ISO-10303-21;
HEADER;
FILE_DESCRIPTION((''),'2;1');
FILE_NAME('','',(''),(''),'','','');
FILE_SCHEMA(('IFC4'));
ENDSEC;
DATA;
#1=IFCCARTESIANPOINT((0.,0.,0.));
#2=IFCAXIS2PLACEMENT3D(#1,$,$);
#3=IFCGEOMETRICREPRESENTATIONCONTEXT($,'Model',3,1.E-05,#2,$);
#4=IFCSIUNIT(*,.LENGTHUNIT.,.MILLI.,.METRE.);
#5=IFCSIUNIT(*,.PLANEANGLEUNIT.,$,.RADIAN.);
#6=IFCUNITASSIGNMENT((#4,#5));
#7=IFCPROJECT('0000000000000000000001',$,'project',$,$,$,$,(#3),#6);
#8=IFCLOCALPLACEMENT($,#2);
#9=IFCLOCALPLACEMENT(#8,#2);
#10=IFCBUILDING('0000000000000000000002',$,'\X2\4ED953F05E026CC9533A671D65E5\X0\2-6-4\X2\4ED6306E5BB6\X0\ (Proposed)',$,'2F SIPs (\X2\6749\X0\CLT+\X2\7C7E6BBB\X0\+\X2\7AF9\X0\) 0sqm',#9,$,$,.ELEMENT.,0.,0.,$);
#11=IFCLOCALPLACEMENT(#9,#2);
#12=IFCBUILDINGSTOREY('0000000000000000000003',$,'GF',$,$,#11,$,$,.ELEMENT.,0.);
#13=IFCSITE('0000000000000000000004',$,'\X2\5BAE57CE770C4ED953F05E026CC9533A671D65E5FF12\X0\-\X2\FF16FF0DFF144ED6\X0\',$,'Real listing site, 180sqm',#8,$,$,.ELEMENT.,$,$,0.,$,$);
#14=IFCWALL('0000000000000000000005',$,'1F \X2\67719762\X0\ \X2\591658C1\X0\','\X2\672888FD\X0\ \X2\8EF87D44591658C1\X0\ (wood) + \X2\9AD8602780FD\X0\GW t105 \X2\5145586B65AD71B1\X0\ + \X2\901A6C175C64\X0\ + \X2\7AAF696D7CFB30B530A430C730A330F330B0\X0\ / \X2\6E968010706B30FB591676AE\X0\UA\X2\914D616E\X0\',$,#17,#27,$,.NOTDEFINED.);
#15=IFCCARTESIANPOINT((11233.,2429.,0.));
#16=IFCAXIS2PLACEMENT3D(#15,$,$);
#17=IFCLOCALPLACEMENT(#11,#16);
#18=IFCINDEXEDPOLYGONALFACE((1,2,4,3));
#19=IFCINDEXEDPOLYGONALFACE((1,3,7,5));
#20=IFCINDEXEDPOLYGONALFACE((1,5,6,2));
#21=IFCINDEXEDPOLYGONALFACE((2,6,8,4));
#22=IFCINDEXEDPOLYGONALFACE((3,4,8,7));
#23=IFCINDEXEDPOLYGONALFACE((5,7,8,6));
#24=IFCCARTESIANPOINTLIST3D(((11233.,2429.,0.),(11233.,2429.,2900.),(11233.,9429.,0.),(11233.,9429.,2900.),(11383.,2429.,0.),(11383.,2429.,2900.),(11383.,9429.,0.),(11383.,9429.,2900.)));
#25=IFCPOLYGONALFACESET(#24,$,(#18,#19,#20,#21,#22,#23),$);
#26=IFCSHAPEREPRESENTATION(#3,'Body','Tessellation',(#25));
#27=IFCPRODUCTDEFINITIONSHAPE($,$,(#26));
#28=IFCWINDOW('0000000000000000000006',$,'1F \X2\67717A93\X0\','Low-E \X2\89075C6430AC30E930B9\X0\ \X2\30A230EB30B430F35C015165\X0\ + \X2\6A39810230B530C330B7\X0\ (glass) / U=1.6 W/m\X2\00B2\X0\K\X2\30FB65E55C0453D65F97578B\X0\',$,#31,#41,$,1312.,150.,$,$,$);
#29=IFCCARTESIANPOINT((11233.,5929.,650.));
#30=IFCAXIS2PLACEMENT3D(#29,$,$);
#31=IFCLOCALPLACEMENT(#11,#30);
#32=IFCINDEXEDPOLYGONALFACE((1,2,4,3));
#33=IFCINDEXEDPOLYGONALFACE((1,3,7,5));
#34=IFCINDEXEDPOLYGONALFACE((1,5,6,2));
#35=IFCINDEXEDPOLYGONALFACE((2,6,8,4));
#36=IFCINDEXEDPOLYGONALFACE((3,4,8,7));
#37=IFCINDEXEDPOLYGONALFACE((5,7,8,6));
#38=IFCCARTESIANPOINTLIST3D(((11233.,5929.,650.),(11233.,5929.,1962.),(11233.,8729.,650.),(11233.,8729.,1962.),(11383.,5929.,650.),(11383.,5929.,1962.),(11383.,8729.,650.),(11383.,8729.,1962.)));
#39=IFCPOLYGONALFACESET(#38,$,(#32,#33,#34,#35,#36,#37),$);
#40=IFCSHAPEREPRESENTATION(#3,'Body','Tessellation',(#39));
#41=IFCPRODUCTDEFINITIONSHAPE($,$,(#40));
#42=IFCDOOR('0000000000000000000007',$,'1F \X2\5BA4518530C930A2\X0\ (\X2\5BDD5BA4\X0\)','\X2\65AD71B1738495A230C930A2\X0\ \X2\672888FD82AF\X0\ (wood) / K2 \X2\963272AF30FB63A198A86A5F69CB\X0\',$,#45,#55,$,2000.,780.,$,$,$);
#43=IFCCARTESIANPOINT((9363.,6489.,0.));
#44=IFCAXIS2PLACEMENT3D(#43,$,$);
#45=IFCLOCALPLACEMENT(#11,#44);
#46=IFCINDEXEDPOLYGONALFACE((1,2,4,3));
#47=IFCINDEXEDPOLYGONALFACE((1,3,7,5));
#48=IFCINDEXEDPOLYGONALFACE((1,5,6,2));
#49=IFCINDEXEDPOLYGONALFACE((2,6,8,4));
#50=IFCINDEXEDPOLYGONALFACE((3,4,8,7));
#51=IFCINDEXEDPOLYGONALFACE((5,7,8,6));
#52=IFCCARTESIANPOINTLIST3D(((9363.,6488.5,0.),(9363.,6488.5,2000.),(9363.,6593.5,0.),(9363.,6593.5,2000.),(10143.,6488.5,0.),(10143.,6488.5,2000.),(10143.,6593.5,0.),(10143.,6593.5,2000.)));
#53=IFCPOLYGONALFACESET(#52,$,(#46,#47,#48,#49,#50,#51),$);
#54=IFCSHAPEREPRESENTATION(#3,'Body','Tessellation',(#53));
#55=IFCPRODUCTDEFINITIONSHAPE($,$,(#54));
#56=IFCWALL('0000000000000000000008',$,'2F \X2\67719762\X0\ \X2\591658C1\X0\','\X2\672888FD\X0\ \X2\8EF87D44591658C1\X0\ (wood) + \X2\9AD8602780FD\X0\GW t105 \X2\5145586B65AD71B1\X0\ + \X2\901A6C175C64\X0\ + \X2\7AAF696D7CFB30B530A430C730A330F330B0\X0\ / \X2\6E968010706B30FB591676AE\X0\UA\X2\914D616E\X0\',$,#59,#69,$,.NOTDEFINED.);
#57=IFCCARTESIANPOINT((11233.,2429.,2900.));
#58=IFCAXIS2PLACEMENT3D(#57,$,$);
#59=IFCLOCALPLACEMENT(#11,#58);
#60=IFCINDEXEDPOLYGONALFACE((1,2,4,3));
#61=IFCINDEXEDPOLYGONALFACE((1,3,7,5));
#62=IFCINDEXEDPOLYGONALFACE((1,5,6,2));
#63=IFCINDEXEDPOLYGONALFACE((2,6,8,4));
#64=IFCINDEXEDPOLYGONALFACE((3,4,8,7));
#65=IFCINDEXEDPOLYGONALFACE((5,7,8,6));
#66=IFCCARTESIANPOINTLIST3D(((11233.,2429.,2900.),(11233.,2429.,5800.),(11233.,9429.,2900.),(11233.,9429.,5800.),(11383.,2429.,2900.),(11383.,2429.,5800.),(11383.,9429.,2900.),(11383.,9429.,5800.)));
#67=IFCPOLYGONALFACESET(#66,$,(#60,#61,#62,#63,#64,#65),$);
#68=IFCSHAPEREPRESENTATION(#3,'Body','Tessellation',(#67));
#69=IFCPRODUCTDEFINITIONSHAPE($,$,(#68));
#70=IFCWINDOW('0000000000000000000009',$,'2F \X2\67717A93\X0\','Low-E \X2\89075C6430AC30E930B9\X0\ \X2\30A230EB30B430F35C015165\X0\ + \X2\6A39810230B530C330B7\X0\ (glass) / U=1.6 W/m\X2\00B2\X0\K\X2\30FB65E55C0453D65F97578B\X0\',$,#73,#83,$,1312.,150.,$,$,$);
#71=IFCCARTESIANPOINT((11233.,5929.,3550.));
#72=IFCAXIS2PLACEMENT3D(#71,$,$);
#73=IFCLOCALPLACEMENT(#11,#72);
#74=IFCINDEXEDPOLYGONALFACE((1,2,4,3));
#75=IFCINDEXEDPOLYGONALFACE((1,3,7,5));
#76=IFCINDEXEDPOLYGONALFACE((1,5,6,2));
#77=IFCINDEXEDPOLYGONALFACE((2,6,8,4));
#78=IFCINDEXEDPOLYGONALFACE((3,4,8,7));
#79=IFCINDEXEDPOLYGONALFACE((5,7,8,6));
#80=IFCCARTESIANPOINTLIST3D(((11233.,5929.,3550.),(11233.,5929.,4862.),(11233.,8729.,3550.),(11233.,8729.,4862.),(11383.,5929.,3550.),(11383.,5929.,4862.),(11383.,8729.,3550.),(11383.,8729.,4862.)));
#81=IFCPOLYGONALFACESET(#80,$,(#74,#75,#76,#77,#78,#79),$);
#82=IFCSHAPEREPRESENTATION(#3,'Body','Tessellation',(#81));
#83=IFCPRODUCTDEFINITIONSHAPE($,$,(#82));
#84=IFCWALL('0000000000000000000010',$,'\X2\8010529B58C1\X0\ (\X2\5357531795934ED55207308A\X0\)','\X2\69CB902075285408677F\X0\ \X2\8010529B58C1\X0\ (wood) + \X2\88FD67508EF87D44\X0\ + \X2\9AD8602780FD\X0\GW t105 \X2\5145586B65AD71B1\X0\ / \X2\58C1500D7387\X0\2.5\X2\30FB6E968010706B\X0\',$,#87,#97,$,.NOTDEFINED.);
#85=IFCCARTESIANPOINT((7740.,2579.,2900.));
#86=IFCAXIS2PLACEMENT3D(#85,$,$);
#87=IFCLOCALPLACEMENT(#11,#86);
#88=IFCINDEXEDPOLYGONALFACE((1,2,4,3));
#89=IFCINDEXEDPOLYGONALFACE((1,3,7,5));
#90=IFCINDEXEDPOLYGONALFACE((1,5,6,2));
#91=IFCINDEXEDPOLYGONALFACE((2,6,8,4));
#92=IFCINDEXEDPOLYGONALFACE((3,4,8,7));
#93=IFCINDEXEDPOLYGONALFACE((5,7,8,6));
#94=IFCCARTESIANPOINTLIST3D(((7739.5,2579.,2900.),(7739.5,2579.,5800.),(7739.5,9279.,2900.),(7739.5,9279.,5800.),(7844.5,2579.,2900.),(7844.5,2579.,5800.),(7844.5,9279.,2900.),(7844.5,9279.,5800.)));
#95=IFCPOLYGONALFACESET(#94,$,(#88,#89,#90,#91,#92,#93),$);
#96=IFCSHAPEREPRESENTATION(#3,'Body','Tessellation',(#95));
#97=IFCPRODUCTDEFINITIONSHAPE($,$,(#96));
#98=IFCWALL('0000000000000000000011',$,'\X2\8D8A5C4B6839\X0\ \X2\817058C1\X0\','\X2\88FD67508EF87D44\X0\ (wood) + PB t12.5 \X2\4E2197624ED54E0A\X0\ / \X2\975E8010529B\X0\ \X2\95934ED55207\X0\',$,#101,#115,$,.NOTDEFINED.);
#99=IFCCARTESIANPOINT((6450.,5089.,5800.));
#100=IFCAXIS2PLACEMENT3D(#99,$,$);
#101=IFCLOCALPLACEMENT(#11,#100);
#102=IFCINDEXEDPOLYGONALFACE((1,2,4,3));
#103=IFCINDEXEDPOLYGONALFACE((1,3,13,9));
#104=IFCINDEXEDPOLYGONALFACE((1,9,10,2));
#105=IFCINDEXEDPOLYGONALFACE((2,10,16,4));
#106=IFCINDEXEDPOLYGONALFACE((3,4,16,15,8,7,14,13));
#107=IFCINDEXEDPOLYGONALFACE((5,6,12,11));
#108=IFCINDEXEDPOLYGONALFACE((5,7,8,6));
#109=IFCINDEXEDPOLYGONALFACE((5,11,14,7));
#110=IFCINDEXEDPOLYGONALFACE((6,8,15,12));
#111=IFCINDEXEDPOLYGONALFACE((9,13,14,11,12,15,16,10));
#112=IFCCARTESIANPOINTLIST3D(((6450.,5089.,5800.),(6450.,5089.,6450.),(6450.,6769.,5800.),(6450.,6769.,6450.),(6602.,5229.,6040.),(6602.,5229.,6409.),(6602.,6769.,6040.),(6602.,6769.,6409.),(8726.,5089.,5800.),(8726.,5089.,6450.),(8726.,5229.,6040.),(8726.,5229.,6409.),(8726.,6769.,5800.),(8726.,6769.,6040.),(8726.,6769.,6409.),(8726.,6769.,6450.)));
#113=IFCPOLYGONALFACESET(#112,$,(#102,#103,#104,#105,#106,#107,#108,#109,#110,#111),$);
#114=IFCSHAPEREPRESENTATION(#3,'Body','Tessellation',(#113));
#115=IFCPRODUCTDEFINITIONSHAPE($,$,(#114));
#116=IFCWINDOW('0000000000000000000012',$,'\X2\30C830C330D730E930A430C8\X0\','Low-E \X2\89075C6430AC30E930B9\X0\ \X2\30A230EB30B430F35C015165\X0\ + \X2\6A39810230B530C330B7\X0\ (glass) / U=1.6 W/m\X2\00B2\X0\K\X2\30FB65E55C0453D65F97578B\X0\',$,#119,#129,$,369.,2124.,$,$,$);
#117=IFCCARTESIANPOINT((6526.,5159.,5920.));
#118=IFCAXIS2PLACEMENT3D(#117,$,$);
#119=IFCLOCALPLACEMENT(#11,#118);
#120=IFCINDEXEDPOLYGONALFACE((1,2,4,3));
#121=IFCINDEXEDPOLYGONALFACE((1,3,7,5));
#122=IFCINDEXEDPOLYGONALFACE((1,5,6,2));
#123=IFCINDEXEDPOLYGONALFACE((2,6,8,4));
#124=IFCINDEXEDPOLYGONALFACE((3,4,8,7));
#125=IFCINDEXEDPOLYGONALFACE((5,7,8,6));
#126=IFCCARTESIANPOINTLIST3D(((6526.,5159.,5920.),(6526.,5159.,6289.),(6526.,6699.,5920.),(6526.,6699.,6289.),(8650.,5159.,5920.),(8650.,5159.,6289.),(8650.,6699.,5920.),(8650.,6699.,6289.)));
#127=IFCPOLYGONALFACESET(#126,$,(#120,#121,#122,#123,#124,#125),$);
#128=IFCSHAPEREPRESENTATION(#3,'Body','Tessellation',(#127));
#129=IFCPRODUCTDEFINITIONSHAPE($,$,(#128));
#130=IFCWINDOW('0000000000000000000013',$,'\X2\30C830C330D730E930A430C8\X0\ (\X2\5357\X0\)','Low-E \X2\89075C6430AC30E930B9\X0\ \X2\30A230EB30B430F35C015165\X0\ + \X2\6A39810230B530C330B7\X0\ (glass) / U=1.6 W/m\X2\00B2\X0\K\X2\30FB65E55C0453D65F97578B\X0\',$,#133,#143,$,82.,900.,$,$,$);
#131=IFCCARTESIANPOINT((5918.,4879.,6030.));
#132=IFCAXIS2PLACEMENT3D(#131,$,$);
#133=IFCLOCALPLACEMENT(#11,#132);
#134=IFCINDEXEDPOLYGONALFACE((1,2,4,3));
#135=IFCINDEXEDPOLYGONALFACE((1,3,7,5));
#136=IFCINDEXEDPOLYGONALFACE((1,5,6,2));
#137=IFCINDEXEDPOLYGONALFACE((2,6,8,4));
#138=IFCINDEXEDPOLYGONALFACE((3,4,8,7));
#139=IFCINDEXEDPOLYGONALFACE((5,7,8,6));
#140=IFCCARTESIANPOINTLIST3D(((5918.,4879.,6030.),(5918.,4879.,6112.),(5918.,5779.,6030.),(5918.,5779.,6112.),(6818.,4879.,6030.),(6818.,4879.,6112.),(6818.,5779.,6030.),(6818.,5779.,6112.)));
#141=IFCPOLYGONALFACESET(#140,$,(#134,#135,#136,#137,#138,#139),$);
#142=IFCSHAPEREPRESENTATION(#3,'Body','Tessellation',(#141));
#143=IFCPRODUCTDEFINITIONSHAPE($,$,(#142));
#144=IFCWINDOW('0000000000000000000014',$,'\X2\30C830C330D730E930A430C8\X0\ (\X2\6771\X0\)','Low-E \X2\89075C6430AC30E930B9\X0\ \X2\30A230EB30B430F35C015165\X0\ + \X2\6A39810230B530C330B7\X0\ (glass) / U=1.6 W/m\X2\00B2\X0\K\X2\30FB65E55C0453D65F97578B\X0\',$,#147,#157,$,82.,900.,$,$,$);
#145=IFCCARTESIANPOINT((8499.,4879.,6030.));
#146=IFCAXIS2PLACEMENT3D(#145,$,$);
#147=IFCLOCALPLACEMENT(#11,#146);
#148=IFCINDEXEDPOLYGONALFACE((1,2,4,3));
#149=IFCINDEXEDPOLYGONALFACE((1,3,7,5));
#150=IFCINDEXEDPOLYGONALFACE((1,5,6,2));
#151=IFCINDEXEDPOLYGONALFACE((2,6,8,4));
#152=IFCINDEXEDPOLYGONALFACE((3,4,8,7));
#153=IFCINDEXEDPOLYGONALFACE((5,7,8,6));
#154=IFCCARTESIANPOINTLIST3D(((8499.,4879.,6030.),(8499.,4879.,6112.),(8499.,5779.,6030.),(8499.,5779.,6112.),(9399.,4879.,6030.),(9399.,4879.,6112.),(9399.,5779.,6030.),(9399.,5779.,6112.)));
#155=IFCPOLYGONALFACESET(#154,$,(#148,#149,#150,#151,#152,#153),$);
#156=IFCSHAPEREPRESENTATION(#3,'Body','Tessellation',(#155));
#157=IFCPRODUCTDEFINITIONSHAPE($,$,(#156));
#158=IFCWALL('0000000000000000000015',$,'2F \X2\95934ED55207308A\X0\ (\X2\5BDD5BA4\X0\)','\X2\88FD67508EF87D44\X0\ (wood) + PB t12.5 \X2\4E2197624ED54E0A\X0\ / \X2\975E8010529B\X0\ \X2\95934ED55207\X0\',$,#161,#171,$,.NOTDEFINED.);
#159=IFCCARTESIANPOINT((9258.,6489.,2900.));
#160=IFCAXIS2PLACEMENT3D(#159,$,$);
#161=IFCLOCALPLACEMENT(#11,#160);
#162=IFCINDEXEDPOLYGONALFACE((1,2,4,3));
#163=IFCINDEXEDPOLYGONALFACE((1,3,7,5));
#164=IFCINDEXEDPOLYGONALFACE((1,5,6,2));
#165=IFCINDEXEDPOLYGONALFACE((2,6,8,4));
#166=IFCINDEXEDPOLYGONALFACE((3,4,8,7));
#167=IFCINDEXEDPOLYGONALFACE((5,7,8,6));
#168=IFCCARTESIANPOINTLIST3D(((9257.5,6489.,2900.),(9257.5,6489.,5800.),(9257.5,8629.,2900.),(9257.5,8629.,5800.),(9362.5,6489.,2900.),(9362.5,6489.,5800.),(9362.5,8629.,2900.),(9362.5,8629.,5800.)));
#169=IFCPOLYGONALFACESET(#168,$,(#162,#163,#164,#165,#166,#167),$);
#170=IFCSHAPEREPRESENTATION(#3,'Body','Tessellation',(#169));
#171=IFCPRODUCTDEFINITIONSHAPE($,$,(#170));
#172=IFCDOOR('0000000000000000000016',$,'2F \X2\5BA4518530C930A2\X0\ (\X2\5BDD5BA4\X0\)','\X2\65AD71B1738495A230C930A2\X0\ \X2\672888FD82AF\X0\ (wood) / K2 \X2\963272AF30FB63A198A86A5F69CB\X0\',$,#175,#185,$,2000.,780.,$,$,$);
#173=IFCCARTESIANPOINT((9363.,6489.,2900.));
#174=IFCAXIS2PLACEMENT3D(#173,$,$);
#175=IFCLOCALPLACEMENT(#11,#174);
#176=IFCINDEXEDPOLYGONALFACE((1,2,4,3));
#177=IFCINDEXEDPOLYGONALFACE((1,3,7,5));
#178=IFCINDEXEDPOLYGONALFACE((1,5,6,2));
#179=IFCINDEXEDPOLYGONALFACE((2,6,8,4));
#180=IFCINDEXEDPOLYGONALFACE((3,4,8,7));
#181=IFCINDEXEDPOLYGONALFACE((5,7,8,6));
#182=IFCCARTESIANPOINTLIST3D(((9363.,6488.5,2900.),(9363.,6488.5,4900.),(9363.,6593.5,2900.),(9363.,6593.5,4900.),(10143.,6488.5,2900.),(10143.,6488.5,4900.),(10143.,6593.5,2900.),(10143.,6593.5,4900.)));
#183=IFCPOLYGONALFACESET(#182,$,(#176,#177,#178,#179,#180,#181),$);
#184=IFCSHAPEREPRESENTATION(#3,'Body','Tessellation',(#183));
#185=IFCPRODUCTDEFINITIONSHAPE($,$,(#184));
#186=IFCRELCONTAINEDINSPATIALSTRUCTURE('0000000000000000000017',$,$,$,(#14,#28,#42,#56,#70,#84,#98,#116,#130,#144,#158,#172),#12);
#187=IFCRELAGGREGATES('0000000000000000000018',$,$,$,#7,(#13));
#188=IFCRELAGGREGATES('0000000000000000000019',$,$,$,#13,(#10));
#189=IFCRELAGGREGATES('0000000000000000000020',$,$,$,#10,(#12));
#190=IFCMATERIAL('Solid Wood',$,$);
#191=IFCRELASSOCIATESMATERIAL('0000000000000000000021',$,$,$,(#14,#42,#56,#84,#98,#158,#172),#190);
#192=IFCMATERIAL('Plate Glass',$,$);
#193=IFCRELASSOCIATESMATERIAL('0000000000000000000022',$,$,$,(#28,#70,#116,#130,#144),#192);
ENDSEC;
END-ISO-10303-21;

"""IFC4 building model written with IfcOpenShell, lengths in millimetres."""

from ifc_helpers import new_model, si_unit, frame, frame_2d, origin, place, context, project, spatial, rectangle, extrude, material, element, fill, save


model = new_model("IFC4")

# Units and contexts
model_context = context("Model", 3, precision=1e-05, world=origin())
ifc_project = project(units=[si_unit("LENGTHUNIT", "METRE", prefix="MILLI"), si_unit("PLANEANGLEUNIT", "RADIAN")], contexts=[model_context])

# Site, building, storey
site_placement = place(None, origin())
site = spatial("IfcSite", under=ifc_project, at=site_placement, Name="宮城県仙台市泉区朝日２-６－４他", ObjectType="Real listing site, 180sqm", CompositionType="ELEMENT", RefElevation=0.0)
building_placement = place(site_placement, origin())
building = spatial("IfcBuilding", under=site, at=building_placement, Name="仙台市泉区朝日2-6-4他の家 (Proposed)", ObjectType="2F SIPs (杉CLT+籾殻+竹) 0sqm", CompositionType="ELEMENT", ElevationOfRefHeight=0.0, ElevationOfTerrain=0.0)
storey_placement = place(building_placement, origin())
storey = spatial("IfcBuildingStorey", under=building, at=storey_placement, Name="GF", CompositionType="ELEMENT", Elevation=0.0)

# Wall, opening, window
ifc_material_1 = material(Name="Solid Wood")
wall_1_placement = place(storey_placement, frame((11233.0, 2429.0, 0.0)))
wall_1 = element("IfcWall", 1, at=wall_1_placement, inside=storey, material=ifc_material_1, Name="1F 東面 外壁", Description="木製 軸組外壁 (wood) + 高性能GW t105 充填断熱 + 通気層 + 窯業系サイディング / 準耐火・外皮UA配慮", PredefinedType="NOTDEFINED", context=model_context, shape_type="SweptSolid", body=[
    extrude(rectangle(XDim=150.0, YDim=7000.0, at=frame_2d((75.0, 3500.0))), frame((11233.0, 2429.0, 0.0)), (0.0, 0.0, 1.0), 2900.0),
])
opening_1_placement = place(storey_placement, frame((11233.0, 5929.0, 650.0)))
opening_1 = element("IfcOpeningElement", 2, at=opening_1_placement, cuts=wall_1, PredefinedType="NOTDEFINED", context=model_context, shape_type="SweptSolid", body=[
    extrude(rectangle(XDim=150.0, YDim=2800.0, at=frame_2d((75.0, 1400.0))), frame((11233.0, 5929.0, 650.0)), (0.0, 0.0, 1.0), 1312.0),
])
ifc_material_2 = material(Name="Plate Glass")
window_1_placement = place(storey_placement, frame((11233.0, 5929.0, 650.0)))
window_1 = element("IfcWindow", 3, at=window_1_placement, inside=storey, material=ifc_material_2, Name="1F 東窓", Description="Low-E 複層ガラス アルゴン封入 + 樹脂サッシ (glass) / U=1.6 W/m²K・日射取得型", OverallHeight=1312.0, OverallWidth=150.0, context=model_context, shape_type="SweptSolid", body=[
    extrude(rectangle(XDim=150.0, YDim=2800.0, at=frame_2d((75.0, 1400.0))), frame((11233.0, 5929.0, 650.0)), (0.0, 0.0, 1.0), 1312.0),
])
fill(opening_1, window_1)

# Door
door_1_placement = place(storey_placement, frame((9363.0, 6489.0, 0.0)))
element("IfcDoor", 4, at=door_1_placement, inside=storey, material=ifc_material_1, Name="1F 室内ドア (寝室)", Description="断熱玄関ドア 木製芯 (wood) / K2 防犯・採風機構", OverallHeight=2000.0, OverallWidth=780.0, context=model_context, shape_type="SweptSolid", body=[
    extrude(rectangle(XDim=780.0, YDim=105.0, at=frame_2d((390.0, 52.0))), frame((9363.0, 6489.0, 0.0)), (0.0, 0.0, 1.0), 2000.0),
])

# Wall, opening, window
wall_2_placement = place(storey_placement, frame((11233.0, 2429.0, 2900.0)))
wall_2 = element("IfcWall", 5, at=wall_2_placement, inside=storey, material=ifc_material_1, Name="2F 東面 外壁", Description="木製 軸組外壁 (wood) + 高性能GW t105 充填断熱 + 通気層 + 窯業系サイディング / 準耐火・外皮UA配慮", PredefinedType="NOTDEFINED", context=model_context, shape_type="SweptSolid", body=[
    extrude(rectangle(XDim=150.0, YDim=7000.0, at=frame_2d((75.0, 3500.0))), frame((11233.0, 2429.0, 2900.0)), (0.0, 0.0, 1.0), 2900.0),
])
opening_2_placement = place(storey_placement, frame((11233.0, 5929.0, 3550.0)))
opening_2 = element("IfcOpeningElement", 6, at=opening_2_placement, cuts=wall_2, PredefinedType="NOTDEFINED", context=model_context, shape_type="SweptSolid", body=[
    extrude(rectangle(XDim=150.0, YDim=2800.0, at=frame_2d((75.0, 1400.0))), frame((11233.0, 5929.0, 3550.0)), (0.0, 0.0, 1.0), 1312.0),
])
window_2_placement = place(storey_placement, frame((11233.0, 5929.0, 3550.0)))
window_2 = element("IfcWindow", 7, at=window_2_placement, inside=storey, material=ifc_material_2, Name="2F 東窓", Description="Low-E 複層ガラス アルゴン封入 + 樹脂サッシ (glass) / U=1.6 W/m²K・日射取得型", OverallHeight=1312.0, OverallWidth=150.0, context=model_context, shape_type="SweptSolid", body=[
    extrude(rectangle(XDim=150.0, YDim=2800.0, at=frame_2d((75.0, 1400.0))), frame((11233.0, 5929.0, 3550.0)), (0.0, 0.0, 1.0), 1312.0),
])
fill(opening_2, window_2)

# Wall
wall_3_placement = place(storey_placement, frame((7740.0, 2579.0, 2900.0)))
element("IfcWall", 8, at=wall_3_placement, inside=storey, material=ifc_material_1, Name="耐力壁 (南北間仕切り)", Description="構造用合板 耐力壁 (wood) + 製材軸組 + 高性能GW t105 充填断熱 / 壁倍率2.5・準耐火", PredefinedType="NOTDEFINED", context=model_context, shape_type="SweptSolid", body=[
    extrude(rectangle(XDim=105.0, YDim=6700.0, at=frame_2d((52.0, 3350.0))), frame((7740.0, 2579.0, 2900.0)), (0.0, 0.0, 1.0), 2900.0),
])

# Wall, openings, windows
wall_4_placement = place(storey_placement, frame((6450.0, 5089.0, 5800.0)))
wall_4 = element("IfcWall", 9, at=wall_4_placement, inside=storey, material=ifc_material_1, Name="越屋根 腰壁", Description="製材軸組 (wood) + PB t12.5 両面仕上 / 非耐力 間仕切", PredefinedType="NOTDEFINED", context=model_context, shape_type="SweptSolid", body=[
    extrude(rectangle(XDim=2276.0, YDim=1680.0, at=frame_2d((1138.0, 840.0))), frame((6450.0, 5089.0, 5800.0)), (0.0, 0.0, 1.0), 650.0),
])
opening_3_placement = place(storey_placement, frame((6526.0, 5159.0, 5920.0)))
opening_3 = element("IfcOpeningElement", 10, at=opening_3_placement, cuts=wall_4, PredefinedType="NOTDEFINED", context=model_context, shape_type="SweptSolid", body=[
    extrude(rectangle(XDim=2124.0, YDim=1540.0, at=frame_2d((1062.0, 770.0))), frame((6526.0, 5159.0, 5920.0)), (0.0, 0.0, 1.0), 369.0),
])
opening_4_placement = place(storey_placement, frame((5918.0, 4879.0, 6030.0)))
opening_4 = element("IfcOpeningElement", 11, at=opening_4_placement, cuts=wall_4, PredefinedType="NOTDEFINED", context=model_context, shape_type="SweptSolid", body=[
    extrude(rectangle(XDim=900.0, YDim=900.0, at=frame_2d((450.0, 450.0))), frame((5918.0, 4879.0, 6030.0)), (0.0, 0.0, 1.0), 82.0),
])
opening_5_placement = place(storey_placement, frame((8499.0, 4879.0, 6030.0)))
opening_5 = element("IfcOpeningElement", 12, at=opening_5_placement, cuts=wall_4, PredefinedType="NOTDEFINED", context=model_context, shape_type="SweptSolid", body=[
    extrude(rectangle(XDim=900.0, YDim=900.0, at=frame_2d((450.0, 450.0))), frame((8499.0, 4879.0, 6030.0)), (0.0, 0.0, 1.0), 82.0),
])
window_3_placement = place(storey_placement, frame((6526.0, 5159.0, 5920.0)))
window_3 = element("IfcWindow", 13, at=window_3_placement, inside=storey, material=ifc_material_2, Name="トップライト", Description="Low-E 複層ガラス アルゴン封入 + 樹脂サッシ (glass) / U=1.6 W/m²K・日射取得型", OverallHeight=369.0, OverallWidth=2124.0, context=model_context, shape_type="SweptSolid", body=[
    extrude(rectangle(XDim=2124.0, YDim=1540.0, at=frame_2d((1062.0, 770.0))), frame((6526.0, 5159.0, 5920.0)), (0.0, 0.0, 1.0), 369.0),
])
fill(opening_3, window_3)
window_4_placement = place(storey_placement, frame((5918.0, 4879.0, 6030.0)))
window_4 = element("IfcWindow", 14, at=window_4_placement, inside=storey, material=ifc_material_2, Name="トップライト (南)", Description="Low-E 複層ガラス アルゴン封入 + 樹脂サッシ (glass) / U=1.6 W/m²K・日射取得型", OverallHeight=82.0, OverallWidth=900.0, context=model_context, shape_type="SweptSolid", body=[
    extrude(rectangle(XDim=900.0, YDim=900.0, at=frame_2d((450.0, 450.0))), frame((5918.0, 4879.0, 6030.0)), (0.0, 0.0, 1.0), 82.0),
])
fill(opening_4, window_4)
window_5_placement = place(storey_placement, frame((8499.0, 4879.0, 6030.0)))
window_5 = element("IfcWindow", 15, at=window_5_placement, inside=storey, material=ifc_material_2, Name="トップライト (東)", Description="Low-E 複層ガラス アルゴン封入 + 樹脂サッシ (glass) / U=1.6 W/m²K・日射取得型", OverallHeight=82.0, OverallWidth=900.0, context=model_context, shape_type="SweptSolid", body=[
    extrude(rectangle(XDim=900.0, YDim=900.0, at=frame_2d((450.0, 450.0))), frame((8499.0, 4879.0, 6030.0)), (0.0, 0.0, 1.0), 82.0),
])
fill(opening_5, window_5)

# Wall
wall_5_placement = place(storey_placement, frame((9258.0, 6489.0, 2900.0)))
element("IfcWall", 16, at=wall_5_placement, inside=storey, material=ifc_material_1, Name="2F 間仕切り (寝室)", Description="製材軸組 (wood) + PB t12.5 両面仕上 / 非耐力 間仕切", PredefinedType="NOTDEFINED", context=model_context, shape_type="SweptSolid", body=[
    extrude(rectangle(XDim=105.0, YDim=2140.0, at=frame_2d((52.0, 1070.0))), frame((9258.0, 6489.0, 2900.0)), (0.0, 0.0, 1.0), 2900.0),
])

# Door
door_2_placement = place(storey_placement, frame((9363.0, 6489.0, 2900.0)))
element("IfcDoor", 17, at=door_2_placement, inside=storey, material=ifc_material_1, Name="2F 室内ドア (寝室)", Description="断熱玄関ドア 木製芯 (wood) / K2 防犯・採風機構", OverallHeight=2000.0, OverallWidth=780.0, context=model_context, shape_type="SweptSolid", body=[
    extrude(rectangle(XDim=780.0, YDim=105.0, at=frame_2d((390.0, 52.0))), frame((9363.0, 6489.0, 2900.0)), (0.0, 0.0, 1.0), 2000.0),
])

save(model, "model.ifc")
